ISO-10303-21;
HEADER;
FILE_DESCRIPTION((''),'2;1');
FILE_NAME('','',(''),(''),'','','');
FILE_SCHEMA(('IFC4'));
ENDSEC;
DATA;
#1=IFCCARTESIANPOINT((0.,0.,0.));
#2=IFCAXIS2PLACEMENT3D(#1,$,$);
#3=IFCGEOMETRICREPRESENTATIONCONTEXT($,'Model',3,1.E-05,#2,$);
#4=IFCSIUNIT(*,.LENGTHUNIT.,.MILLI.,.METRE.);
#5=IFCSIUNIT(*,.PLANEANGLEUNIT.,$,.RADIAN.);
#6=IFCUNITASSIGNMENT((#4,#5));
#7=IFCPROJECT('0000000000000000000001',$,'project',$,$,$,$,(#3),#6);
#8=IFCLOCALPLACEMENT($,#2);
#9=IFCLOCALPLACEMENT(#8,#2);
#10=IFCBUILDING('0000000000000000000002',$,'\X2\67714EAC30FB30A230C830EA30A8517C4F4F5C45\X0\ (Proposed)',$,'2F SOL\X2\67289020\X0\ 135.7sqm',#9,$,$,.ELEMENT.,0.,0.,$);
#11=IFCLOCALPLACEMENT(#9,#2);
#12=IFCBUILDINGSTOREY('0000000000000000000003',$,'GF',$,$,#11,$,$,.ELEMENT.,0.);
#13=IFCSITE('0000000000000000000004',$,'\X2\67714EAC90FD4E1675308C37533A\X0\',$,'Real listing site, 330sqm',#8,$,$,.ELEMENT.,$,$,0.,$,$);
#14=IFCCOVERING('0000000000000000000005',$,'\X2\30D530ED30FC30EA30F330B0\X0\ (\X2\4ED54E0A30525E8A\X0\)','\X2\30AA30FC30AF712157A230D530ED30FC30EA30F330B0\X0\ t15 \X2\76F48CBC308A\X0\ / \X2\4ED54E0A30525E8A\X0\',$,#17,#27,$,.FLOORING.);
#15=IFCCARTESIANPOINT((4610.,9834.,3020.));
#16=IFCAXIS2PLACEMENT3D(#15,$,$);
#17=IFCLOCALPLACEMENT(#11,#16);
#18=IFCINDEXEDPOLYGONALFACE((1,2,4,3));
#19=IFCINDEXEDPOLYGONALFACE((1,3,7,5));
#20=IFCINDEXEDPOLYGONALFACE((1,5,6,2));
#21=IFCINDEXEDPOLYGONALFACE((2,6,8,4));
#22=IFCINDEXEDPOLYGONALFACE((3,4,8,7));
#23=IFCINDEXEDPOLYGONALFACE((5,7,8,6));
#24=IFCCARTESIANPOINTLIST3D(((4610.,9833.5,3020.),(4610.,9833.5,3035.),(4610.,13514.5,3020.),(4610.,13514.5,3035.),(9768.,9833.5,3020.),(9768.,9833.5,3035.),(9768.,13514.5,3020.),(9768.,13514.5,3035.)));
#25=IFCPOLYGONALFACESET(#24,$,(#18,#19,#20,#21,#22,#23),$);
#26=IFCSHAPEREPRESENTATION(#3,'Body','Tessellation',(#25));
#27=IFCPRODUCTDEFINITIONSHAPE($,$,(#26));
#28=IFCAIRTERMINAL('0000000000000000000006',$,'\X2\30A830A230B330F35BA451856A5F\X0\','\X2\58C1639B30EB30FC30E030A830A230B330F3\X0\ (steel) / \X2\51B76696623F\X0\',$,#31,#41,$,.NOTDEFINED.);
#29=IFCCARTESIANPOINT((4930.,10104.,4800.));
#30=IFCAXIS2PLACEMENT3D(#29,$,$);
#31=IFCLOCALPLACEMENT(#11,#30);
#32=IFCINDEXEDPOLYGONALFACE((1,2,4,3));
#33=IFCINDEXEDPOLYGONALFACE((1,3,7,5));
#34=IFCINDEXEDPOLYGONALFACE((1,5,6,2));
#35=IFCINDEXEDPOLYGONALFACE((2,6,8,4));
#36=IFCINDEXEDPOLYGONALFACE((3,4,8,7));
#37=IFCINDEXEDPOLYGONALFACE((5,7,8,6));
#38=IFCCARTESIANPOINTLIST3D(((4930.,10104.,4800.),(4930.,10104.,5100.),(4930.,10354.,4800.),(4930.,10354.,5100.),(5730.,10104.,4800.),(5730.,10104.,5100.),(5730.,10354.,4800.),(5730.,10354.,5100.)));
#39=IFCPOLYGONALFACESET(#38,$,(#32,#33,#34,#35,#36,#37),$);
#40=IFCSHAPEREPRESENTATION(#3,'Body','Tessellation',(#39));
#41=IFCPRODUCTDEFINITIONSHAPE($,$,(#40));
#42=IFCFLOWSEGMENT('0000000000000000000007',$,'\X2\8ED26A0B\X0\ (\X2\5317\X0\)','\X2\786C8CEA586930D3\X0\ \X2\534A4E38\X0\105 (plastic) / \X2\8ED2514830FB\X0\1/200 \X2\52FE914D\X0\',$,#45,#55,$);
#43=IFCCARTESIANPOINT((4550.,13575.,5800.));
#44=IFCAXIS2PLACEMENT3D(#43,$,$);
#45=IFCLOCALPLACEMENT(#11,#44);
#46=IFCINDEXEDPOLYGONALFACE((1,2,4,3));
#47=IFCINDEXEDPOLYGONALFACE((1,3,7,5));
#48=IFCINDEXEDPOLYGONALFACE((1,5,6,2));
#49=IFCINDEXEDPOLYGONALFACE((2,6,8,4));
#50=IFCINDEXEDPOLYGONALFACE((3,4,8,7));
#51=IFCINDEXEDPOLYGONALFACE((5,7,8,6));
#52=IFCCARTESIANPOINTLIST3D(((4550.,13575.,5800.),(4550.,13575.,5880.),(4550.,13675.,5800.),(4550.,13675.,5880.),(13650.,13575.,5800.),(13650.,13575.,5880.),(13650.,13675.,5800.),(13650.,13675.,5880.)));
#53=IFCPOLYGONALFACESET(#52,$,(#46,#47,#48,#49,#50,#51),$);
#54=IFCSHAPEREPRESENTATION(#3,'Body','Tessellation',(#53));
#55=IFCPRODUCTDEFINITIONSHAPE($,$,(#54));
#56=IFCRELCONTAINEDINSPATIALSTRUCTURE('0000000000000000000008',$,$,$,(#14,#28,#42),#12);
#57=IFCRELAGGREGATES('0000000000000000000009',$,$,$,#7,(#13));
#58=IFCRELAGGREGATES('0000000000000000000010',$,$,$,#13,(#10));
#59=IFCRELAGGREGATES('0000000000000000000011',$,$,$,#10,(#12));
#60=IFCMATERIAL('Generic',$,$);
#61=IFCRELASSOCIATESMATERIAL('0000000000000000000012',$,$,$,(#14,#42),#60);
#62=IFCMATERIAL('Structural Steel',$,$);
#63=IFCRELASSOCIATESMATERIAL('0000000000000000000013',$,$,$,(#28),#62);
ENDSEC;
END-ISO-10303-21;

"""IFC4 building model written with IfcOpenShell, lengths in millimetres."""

from ifc_helpers import new_model, si_unit, frame, frame_2d, origin, place, context, project, spatial, rectangle, extrude, material, element, save


model = new_model("IFC4")

# Units and contexts
model_context = context("Model", 3, precision=1e-05, world=origin())
ifc_project = project(units=[si_unit("LENGTHUNIT", "METRE", prefix="MILLI"), si_unit("PLANEANGLEUNIT", "RADIAN")], contexts=[model_context])

# Site, building, storey
site_placement = place(None, origin())
site = spatial("IfcSite", under=ifc_project, at=site_placement, Name="東京都世田谷区", ObjectType="Real listing site, 330sqm", CompositionType="ELEMENT", RefElevation=0.0)
building_placement = place(site_placement, origin())
building = spatial("IfcBuilding", under=site, at=building_placement, Name="東京・アトリエ兼住居 (Proposed)", ObjectType="2F SOL木造 135.7sqm", CompositionType="ELEMENT", ElevationOfRefHeight=0.0, ElevationOfTerrain=0.0)
storey_placement = place(building_placement, origin())
storey = spatial("IfcBuildingStorey", under=building, at=storey_placement, Name="GF", CompositionType="ELEMENT", Elevation=0.0)

# Shared definitions
ifc_material_1 = material(Name="Structural Steel")

# Covering
ifc_material_2 = material(Name="Generic")
covering_placement = place(storey_placement, frame((4610.0, 9834.0, 3020.0)))
element("IfcCovering", 1, at=covering_placement, inside=storey, material=ifc_material_2, Name="フローリング (仕上げ床)", Description="オーク無垢フローリング t15 直貼り / 仕上げ床", PredefinedType="FLOORING", context=model_context, shape_type="SweptSolid", body=[
    extrude(rectangle(XDim=5158.0, YDim=3681.0, at=frame_2d((2579.0, 1840.0))), frame((4610.0, 9834.0, 3020.0)), (0.0, 0.0, 1.0), 15.0),
])

# Air terminal
air_terminal_placement = place(storey_placement, frame((4930.0, 10104.0, 4800.0)))
element("IfcAirTerminal", 2, at=air_terminal_placement, inside=storey, material=ifc_material_1, Name="エアコン室内機", Description="壁掛ルームエアコン (steel) / 冷暖房", PredefinedType="NOTDEFINED", context=model_context, shape_type="SweptSolid", body=[
    extrude(rectangle(XDim=800.0, YDim=250.0, at=frame_2d((400.0, 125.0))), frame((4930.0, 10104.0, 4800.0)), (0.0, 0.0, 1.0), 300.0),
])

# Flow segment
flow_segment_placement = place(storey_placement, frame((4550.0, 13575.0, 5800.0)))
element("IfcFlowSegment", 3, at=flow_segment_placement, inside=storey, material=ifc_material_2, Name="軒樋 (北)", Description="硬質塩ビ 半丸105 (plastic) / 軒先・1/200 勾配", context=model_context, shape_type="SweptSolid", body=[
    extrude(rectangle(XDim=9100.0, YDim=100.0, at=frame_2d((4550.0, 50.0))), frame((4550.0, 13575.0, 5800.0)), (0.0, 0.0, 1.0), 80.0),
])

save(model, "model.ifc")
